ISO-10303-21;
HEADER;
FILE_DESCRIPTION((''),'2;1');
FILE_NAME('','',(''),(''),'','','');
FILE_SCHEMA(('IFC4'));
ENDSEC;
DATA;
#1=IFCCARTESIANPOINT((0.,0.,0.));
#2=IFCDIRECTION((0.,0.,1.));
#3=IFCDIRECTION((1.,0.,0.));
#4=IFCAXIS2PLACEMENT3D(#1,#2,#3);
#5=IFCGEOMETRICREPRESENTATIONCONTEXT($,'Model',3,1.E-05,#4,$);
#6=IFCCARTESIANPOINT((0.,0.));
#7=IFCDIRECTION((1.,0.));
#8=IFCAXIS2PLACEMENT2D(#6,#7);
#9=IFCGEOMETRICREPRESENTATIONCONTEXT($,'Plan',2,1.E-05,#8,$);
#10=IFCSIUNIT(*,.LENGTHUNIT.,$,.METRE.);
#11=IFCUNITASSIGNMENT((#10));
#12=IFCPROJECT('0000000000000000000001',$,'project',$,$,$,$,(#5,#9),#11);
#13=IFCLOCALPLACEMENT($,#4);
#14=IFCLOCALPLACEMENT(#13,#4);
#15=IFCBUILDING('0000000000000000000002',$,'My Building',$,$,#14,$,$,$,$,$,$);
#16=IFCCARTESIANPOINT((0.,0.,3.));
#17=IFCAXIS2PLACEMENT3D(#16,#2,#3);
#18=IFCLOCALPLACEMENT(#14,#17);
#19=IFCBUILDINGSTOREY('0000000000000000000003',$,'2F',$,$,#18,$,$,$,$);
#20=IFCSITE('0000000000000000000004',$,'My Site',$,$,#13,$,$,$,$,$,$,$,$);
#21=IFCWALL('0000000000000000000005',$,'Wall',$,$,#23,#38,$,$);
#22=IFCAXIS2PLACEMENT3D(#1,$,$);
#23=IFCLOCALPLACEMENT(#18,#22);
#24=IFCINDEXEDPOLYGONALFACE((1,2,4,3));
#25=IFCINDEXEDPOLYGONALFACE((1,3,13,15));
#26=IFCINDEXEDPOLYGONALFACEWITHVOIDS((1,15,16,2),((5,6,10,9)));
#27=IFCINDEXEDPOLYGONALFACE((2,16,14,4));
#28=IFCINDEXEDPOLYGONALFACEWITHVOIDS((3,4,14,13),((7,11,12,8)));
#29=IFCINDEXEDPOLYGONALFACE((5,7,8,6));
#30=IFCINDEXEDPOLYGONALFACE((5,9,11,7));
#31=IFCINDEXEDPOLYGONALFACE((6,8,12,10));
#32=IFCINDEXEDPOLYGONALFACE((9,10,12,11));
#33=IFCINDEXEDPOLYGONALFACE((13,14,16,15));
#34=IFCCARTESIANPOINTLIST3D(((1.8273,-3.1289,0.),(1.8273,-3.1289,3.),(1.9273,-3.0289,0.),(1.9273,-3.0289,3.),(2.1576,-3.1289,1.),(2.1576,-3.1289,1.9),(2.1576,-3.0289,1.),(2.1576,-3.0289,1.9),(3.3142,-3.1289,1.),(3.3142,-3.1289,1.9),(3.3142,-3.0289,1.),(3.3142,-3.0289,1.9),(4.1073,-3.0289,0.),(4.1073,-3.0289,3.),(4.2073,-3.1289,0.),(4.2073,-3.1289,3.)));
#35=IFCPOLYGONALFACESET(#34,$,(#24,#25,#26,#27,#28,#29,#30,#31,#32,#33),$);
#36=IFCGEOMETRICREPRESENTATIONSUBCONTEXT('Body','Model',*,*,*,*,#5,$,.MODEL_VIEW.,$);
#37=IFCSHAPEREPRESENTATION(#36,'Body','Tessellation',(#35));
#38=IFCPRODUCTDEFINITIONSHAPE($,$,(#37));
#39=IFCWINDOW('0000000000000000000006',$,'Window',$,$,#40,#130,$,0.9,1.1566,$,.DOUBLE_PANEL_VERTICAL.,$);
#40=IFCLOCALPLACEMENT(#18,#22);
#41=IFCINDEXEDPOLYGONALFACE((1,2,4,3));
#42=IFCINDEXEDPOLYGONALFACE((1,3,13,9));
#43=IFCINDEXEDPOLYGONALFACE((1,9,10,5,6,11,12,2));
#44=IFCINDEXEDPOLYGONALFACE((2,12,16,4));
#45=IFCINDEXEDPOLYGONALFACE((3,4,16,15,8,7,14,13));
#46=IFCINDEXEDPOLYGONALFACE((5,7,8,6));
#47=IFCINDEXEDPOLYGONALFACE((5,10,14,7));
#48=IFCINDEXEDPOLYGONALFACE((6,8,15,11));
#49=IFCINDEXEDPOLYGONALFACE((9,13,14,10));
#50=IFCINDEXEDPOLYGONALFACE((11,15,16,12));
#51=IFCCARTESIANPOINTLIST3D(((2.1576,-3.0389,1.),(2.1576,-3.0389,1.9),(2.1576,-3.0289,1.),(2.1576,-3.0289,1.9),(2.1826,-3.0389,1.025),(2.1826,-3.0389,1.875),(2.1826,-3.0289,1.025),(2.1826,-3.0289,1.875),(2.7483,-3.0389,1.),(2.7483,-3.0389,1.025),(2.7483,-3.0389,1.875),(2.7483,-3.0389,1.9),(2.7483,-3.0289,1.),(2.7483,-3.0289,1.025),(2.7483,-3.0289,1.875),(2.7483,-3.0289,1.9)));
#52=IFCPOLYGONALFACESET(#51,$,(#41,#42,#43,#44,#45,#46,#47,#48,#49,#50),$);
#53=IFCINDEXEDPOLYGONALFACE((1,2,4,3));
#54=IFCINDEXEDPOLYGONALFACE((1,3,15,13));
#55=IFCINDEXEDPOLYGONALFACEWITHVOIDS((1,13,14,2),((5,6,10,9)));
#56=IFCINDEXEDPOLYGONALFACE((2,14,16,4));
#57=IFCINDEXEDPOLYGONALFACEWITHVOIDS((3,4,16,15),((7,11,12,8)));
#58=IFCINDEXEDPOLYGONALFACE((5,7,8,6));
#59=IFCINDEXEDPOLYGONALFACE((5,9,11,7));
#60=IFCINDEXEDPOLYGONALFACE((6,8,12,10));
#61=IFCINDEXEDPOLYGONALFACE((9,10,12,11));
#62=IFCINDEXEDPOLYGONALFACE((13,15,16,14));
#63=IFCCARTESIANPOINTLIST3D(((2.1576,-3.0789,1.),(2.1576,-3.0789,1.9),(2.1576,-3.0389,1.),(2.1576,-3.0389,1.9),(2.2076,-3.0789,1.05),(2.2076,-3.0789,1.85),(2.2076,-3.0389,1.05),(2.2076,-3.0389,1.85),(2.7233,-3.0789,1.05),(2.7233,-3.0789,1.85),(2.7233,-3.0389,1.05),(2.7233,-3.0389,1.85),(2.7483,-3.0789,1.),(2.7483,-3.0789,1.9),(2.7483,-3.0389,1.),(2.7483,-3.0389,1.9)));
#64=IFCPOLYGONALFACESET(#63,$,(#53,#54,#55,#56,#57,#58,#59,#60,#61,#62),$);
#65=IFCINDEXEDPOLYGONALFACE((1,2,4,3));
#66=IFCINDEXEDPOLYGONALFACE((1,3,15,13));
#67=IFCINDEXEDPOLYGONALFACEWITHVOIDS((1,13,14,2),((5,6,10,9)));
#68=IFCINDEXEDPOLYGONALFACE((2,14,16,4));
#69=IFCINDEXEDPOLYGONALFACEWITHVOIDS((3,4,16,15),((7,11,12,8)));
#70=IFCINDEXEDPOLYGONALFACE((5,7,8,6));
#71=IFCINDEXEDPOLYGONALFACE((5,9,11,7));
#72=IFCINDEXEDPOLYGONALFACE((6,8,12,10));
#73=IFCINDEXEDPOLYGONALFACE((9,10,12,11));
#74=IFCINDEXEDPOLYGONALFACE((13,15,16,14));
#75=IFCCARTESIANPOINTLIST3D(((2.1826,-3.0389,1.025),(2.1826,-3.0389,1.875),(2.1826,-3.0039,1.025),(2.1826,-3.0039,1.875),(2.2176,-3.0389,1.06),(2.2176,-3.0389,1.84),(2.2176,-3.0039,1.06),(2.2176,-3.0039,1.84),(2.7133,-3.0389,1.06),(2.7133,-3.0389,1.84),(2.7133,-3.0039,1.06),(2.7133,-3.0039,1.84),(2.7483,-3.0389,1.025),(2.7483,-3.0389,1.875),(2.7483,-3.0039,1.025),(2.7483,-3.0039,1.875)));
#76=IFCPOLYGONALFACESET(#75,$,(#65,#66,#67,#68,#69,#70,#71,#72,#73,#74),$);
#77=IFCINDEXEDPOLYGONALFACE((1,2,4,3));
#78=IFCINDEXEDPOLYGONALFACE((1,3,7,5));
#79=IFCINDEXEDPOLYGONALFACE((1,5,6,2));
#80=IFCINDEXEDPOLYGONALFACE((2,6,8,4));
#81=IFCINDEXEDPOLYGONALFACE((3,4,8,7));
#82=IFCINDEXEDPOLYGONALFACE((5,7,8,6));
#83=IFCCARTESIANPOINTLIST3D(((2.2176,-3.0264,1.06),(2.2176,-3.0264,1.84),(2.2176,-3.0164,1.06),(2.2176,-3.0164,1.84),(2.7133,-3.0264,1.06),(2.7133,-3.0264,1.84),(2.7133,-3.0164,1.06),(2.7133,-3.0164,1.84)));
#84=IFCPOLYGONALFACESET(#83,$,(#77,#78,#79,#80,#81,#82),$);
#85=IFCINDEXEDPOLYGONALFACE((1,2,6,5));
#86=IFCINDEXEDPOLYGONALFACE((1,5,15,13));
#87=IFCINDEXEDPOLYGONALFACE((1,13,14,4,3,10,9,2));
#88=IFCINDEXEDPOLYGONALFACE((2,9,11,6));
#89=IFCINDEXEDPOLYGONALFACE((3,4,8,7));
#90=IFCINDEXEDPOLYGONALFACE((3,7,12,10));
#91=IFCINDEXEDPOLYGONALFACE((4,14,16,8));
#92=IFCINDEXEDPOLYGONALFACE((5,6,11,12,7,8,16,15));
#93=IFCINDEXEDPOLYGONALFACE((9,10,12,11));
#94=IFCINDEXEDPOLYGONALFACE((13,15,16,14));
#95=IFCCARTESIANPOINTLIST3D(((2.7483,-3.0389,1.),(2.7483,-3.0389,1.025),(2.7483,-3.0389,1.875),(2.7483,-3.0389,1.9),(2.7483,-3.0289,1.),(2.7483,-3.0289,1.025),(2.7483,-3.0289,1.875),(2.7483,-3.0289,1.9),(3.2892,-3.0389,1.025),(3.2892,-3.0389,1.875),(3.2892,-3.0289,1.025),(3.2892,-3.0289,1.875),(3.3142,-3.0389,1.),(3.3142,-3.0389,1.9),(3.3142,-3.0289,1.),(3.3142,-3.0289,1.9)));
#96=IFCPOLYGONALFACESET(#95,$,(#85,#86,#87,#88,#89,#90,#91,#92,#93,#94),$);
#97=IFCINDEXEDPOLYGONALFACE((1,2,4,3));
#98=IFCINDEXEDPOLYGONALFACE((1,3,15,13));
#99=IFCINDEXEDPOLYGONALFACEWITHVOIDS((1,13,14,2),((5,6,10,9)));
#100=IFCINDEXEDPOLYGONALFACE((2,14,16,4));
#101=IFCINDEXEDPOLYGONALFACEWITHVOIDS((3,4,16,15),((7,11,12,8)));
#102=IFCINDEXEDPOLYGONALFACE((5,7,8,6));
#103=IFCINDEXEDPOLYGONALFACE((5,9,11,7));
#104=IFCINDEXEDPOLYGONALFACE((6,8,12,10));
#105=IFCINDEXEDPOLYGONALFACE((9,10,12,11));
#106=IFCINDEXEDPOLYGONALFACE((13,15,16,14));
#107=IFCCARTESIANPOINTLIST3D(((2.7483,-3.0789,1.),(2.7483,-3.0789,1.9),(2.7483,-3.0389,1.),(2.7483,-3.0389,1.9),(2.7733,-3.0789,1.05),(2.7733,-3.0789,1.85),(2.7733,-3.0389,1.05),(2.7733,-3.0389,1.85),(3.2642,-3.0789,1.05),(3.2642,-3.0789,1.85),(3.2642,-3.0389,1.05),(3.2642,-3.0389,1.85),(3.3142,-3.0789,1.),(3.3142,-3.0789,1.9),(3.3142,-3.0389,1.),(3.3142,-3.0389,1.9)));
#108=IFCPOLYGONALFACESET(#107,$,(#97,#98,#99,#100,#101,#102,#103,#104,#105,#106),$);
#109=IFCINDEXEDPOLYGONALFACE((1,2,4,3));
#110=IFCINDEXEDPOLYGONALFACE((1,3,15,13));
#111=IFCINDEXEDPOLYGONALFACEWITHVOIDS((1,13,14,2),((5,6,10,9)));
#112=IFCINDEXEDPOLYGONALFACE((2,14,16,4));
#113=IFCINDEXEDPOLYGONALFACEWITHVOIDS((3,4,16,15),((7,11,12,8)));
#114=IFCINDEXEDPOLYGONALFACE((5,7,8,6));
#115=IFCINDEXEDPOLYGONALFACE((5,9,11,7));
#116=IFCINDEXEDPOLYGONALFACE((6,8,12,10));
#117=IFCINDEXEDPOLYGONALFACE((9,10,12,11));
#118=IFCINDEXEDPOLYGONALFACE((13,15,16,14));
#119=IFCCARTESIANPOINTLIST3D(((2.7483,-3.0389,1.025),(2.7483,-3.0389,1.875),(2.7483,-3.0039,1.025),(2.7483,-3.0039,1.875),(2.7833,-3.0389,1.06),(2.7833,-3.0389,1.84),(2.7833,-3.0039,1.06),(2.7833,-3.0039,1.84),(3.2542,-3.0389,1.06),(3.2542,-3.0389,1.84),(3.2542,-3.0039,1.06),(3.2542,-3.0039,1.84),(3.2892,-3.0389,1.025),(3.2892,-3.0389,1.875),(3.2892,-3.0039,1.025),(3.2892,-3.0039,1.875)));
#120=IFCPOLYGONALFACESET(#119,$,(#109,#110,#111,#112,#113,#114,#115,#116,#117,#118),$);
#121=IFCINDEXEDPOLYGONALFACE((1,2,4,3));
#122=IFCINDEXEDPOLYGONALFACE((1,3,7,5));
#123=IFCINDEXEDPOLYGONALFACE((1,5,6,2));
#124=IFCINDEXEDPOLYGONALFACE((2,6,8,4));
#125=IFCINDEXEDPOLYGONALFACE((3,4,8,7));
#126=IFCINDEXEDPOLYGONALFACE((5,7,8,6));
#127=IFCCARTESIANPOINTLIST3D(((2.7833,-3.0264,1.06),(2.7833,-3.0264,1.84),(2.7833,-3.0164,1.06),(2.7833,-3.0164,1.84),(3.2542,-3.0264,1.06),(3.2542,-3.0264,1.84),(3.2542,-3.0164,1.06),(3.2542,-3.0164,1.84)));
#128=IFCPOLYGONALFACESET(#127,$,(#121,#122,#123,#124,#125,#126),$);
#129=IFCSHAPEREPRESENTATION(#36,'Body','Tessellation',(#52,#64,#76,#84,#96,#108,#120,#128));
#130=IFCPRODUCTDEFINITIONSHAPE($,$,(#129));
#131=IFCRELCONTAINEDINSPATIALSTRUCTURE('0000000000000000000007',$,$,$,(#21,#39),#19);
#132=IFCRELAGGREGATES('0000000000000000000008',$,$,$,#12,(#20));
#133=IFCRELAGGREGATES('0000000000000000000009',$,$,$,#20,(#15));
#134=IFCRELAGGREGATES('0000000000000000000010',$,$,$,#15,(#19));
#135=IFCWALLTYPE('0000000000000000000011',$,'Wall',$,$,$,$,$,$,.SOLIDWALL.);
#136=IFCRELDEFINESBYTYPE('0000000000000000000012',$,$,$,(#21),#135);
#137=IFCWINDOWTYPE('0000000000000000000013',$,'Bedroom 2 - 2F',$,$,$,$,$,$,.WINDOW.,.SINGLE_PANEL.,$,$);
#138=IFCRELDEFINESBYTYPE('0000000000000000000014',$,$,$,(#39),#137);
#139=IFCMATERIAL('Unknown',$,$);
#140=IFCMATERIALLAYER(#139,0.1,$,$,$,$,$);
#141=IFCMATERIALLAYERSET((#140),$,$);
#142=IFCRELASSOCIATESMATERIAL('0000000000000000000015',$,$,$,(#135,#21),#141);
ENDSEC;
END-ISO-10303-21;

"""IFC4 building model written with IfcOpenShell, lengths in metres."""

from ifc_helpers import new_model, entity, si_unit, frame, origin_with_axes, origin_2d_with_axis, place, context, subcontext, project, spatial, line, indexed_curve, outline, extrude, shape, source, transform, mapped, material, layer, layer_set, layer_usage, type_object, type_shapes, element, fill, save


model = new_model("IFC4")

# Units and contexts
model_context = context("Model", 3, precision=1e-05, world=origin_with_axes())
plan_context = context("Plan", 2, precision=1e-05, world=origin_2d_with_axis())
body_context_1 = subcontext(model_context, "Body", "Model", "MODEL_VIEW")
body_context_2 = subcontext(plan_context, "Body", "Plan", "PLAN_VIEW")
ifc_project = project(units=[si_unit("LENGTHUNIT", "METRE")], contexts=[model_context, plan_context])

# Site, building, storey
site_placement = place(None, origin_with_axes())
site = spatial("IfcSite", under=ifc_project, at=site_placement, Name="My Site")
building_placement = place(site_placement, origin_with_axes())
building = spatial("IfcBuilding", under=site, at=building_placement, Name="My Building")
storey_placement = place(building_placement, frame((0.0, 0.0, 3.0), z_axis=(0.0, 0.0, 1.0), x_axis=(1.0, 0.0, 0.0)))
storey = spatial("IfcBuildingStorey", under=building, at=storey_placement, Name="2F")

# Shared definitions
ifc_material_1 = material(Name="Unknown")
ifc_layer_1 = layer(ifc_material_1, 0.1)
ifc_layer_set_1 = layer_set([ifc_layer_1])
wall_type_1 = type_object("IfcWallType", Name="Wall", PredefinedType="SOLIDWALL", material=ifc_layer_set_1)

# Wall, opening, window
ifc_layer_usage_1 = layer_usage(ifc_layer_set_1, "AXIS2", "POSITIVE", 0.0)
wall_1_placement = place(storey_placement, frame((1.8273, -3.1289, 0.0), z_axis=(0.0, 0.0, 1.0), x_axis=(1.0, 0.0, 0.0)))
wall_1 = element("IfcWall", 1, at=wall_1_placement, inside=storey, type_object=wall_type_1, material=ifc_layer_usage_1, Name="Wall", context=body_context_1, shape_type="SweptSolid", body=[
    extrude(outline(indexed_curve([(0.0, 0.0), (0.1, 0.1), (2.28, 0.1), (2.38, 0.0)], segments=[line(1, 2, 3, 4, 1)])), origin_with_axes(), (0.0, 0.0, 1.0), 3.0),
])
shared_shape_1 = source(origin_with_axes(), body_context_1, "Body", "SweptSolid", [
    extrude(outline(indexed_curve([(0.0, 0.0), (1.1566, 0.0), (1.1566, 0.9), (0.0, 0.9)], segments=[line(1, 2, 3, 4, 1)])), frame((0.0, -0.6, 0.0), z_axis=(0.0, -1.0, 0.0), x_axis=(1.0, 0.0, 0.0)), (0.0, 0.0, -1.0), 1.2),
])
opening_1_placement = place(wall_1_placement, frame((0.3303, 0.0, 1.0), z_axis=(0.0, 0.0, 1.0), x_axis=(1.0, 0.0, 0.0)))
opening_1 = element("IfcOpeningElement", 2, at=opening_1_placement, cuts=wall_1, PredefinedType="OPENING", context=body_context_1, shape_type="MappedRepresentation", body=[
    mapped(shared_shape_1, transform((0.0, 0.0, 0.0), x_axis=(1.0, 0.0, 0.0), y_axis=(0.0, 1.0, 0.0), z_axis=(0.0, 0.0, 1.0), scale=1.0)),
])
window_type_1 = type_object("IfcWindowType", Name="Bedroom 2 - 2F", PartitioningType="SINGLE_PANEL", PredefinedType="WINDOW")
shared_shape_2 = source(origin_with_axes(), body_context_1, "Body", "SweptSolid", [
    extrude(outline(indexed_curve([(0.5908, 0.0), (0.0, 0.0), (0.0, 0.9), (0.5908, 0.9), (0.5908, 0.875), (0.025, 0.875), (0.025, 0.025), (0.5908, 0.025)], segments=[line(1, 2, 3, 4, 5, 6, 7, 8, 1)])), frame((0.0, 0.09, 0.0), z_axis=(0.0, -1.0, 0.0), x_axis=(1.0, 0.0, 0.0)), (0.0, 0.0, -1.0), 0.01),
    extrude(outline(indexed_curve([(0.0, 0.0), (0.5908, 0.0), (0.5908, 0.9), (0.0, 0.9)], segments=[line(1, 2, 3, 4, 1)]), holes=[indexed_curve([(0.05, 0.05), (0.5658, 0.05), (0.5658, 0.85), (0.05, 0.85)], segments=[line(1, 2, 3, 4, 1)])]), frame((0.0, 0.05, 0.0), z_axis=(0.0, -1.0, 0.0), x_axis=(1.0, 0.0, 0.0)), (0.0, 0.0, -1.0), 0.04),
    extrude(outline(indexed_curve([(0.0, 0.0), (0.5658, 0.0), (0.5658, 0.85), (0.0, 0.85)], segments=[line(1, 2, 3, 4, 1)]), holes=[indexed_curve([(0.035, 0.035), (0.5308, 0.035), (0.5308, 0.815), (0.035, 0.815)], segments=[line(1, 2, 3, 4, 1)])]), frame((0.025, 0.09, 0.025), z_axis=(0.0, -1.0, 0.0), x_axis=(1.0, 0.0, 0.0)), (0.0, 0.0, -1.0), 0.035),
    extrude(outline(indexed_curve([(0.035, 0.035), (0.5308, 0.035), (0.5308, 0.815), (0.035, 0.815)], segments=[line(1, 2, 3, 4, 1)])), frame((0.025, 0.1025, 0.025), z_axis=(0.0, -1.0, 0.0), x_axis=(1.0, 0.0, 0.0)), (0.0, 0.0, -1.0), 0.01),
    extrude(outline(indexed_curve([(0.0, 0.9), (0.5659, 0.9), (0.5659, 0.0), (0.0, 0.0), (0.0, 0.025), (0.5409, 0.025), (0.5409, 0.875), (0.0, 0.875)], segments=[line(1, 2, 3, 4, 5, 6, 7, 8, 1)])), frame((0.5908, 0.09, 0.0), z_axis=(0.0, -1.0, 0.0), x_axis=(1.0, 0.0, 0.0)), (0.0, 0.0, -1.0), 0.01),
    extrude(outline(indexed_curve([(0.0, 0.0), (0.5659, 0.0), (0.5659, 0.9), (0.0, 0.9)], segments=[line(1, 2, 3, 4, 1)]), holes=[indexed_curve([(0.025, 0.05), (0.5159, 0.05), (0.5159, 0.85), (0.025, 0.85)], segments=[line(1, 2, 3, 4, 1)])]), frame((0.5908, 0.05, 0.0), z_axis=(0.0, -1.0, 0.0), x_axis=(1.0, 0.0, 0.0)), (0.0, 0.0, -1.0), 0.04),
    extrude(outline(indexed_curve([(0.0, 0.0), (0.5409, 0.0), (0.5409, 0.85), (0.0, 0.85)], segments=[line(1, 2, 3, 4, 1)]), holes=[indexed_curve([(0.035, 0.035), (0.5059, 0.035), (0.5059, 0.815), (0.035, 0.815)], segments=[line(1, 2, 3, 4, 1)])]), frame((0.5908, 0.09, 0.025), z_axis=(0.0, -1.0, 0.0), x_axis=(1.0, 0.0, 0.0)), (0.0, 0.0, -1.0), 0.035),
    extrude(outline(indexed_curve([(0.035, 0.035), (0.5059, 0.035), (0.5059, 0.815), (0.035, 0.815)], segments=[line(1, 2, 3, 4, 1)])), frame((0.5908, 0.1025, 0.025), z_axis=(0.0, -1.0, 0.0), x_axis=(1.0, 0.0, 0.0)), (0.0, 0.0, -1.0), 0.01),
])
shared_shape_3 = source(origin_with_axes(), body_context_2, "Body", "Curve2D", [
    entity("IfcIndexedPolyCurve", entity("IfcCartesianPointList2D", [[0.05, 0.05], [0.5658, 0.05]])),
    entity("IfcIndexedPolyCurve", entity("IfcCartesianPointList2D", [[0.0, 0.1], [0.025, 0.1], [0.025, 0.09], [0.05, 0.09], [0.05, 0.05], [0.0, 0.05]]), [entity("IfcLineIndex", [1, 2, 3, 4, 5, 6, 1])]),
    entity("IfcIndexedPolyCurve", entity("IfcCartesianPointList2D", [[0.5908, 0.1], [0.5908, 0.1], [0.5908, 0.09], [0.5658, 0.09], [0.5658, 0.05], [0.5908, 0.05]])),
    entity("IfcIndexedPolyCurve", entity("IfcCartesianPointList2D", [[0.025, 0.09], [0.06, 0.09], [0.06, 0.125], [0.025, 0.125]]), [entity("IfcLineIndex", [1, 2, 3, 4, 1])]),
    entity("IfcIndexedPolyCurve", entity("IfcCartesianPointList2D", [[0.5908, 0.09], [0.5558, 0.09], [0.5558, 0.125], [0.5908, 0.125]]), [entity("IfcLineIndex", [1, 2, 3, 4, 1])]),
    entity("IfcIndexedPolyCurve", entity("IfcCartesianPointList2D", [[0.06, 0.09], [0.5558, 0.09]])),
    entity("IfcIndexedPolyCurve", entity("IfcCartesianPointList2D", [[0.06, 0.125], [0.5558, 0.125]])),
    entity("IfcIndexedPolyCurve", entity("IfcCartesianPointList2D", [[0.06, 0.1075], [0.5558, 0.1075]])),
    entity("IfcIndexedPolyCurve", entity("IfcCartesianPointList2D", [[0.6158, 0.05], [1.1066, 0.05]])),
    entity("IfcIndexedPolyCurve", entity("IfcCartesianPointList2D", [[0.5908, 0.1], [0.5908, 0.1], [0.5908, 0.09], [0.6158, 0.09], [0.6158, 0.05], [0.5908, 0.05]])),
    entity("IfcIndexedPolyCurve", entity("IfcCartesianPointList2D", [[1.1566, 0.1], [1.1316, 0.1], [1.1316, 0.09], [1.1066, 0.09], [1.1066, 0.05], [1.1566, 0.05]]), [entity("IfcLineIndex", [1, 2, 3, 4, 5, 6, 1])]),
    entity("IfcIndexedPolyCurve", entity("IfcCartesianPointList2D", [[0.5908, 0.09], [0.6258, 0.09], [0.6258, 0.125], [0.5908, 0.125]]), [entity("IfcLineIndex", [1, 2, 3, 4, 1])]),
    entity("IfcIndexedPolyCurve", entity("IfcCartesianPointList2D", [[1.1316, 0.09], [1.0966, 0.09], [1.0966, 0.125], [1.1316, 0.125]]), [entity("IfcLineIndex", [1, 2, 3, 4, 1])]),
    entity("IfcIndexedPolyCurve", entity("IfcCartesianPointList2D", [[0.6258, 0.09], [1.0966, 0.09]])),
    entity("IfcIndexedPolyCurve", entity("IfcCartesianPointList2D", [[0.6258, 0.125], [1.0966, 0.125]])),
    entity("IfcIndexedPolyCurve", entity("IfcCartesianPointList2D", [[0.6258, 0.1075], [1.0966, 0.1075]])),
])
type_shapes(window_type_1, [shared_shape_2, shared_shape_3])
window_1_placement = place(opening_1_placement, origin_with_axes())
window_1 = element("IfcWindow", 3, at=window_1_placement, inside=storey, type_object=window_type_1, Name="Window", OverallHeight=0.9, OverallWidth=1.1566, PartitioningType="DOUBLE_PANEL_VERTICAL", shapes=[
    shape(body_context_1, "Body", "MappedRepresentation", [mapped(shared_shape_2, transform((0.0, 0.0, 0.0), x_axis=(1.0, 0.0, 0.0), y_axis=(0.0, 1.0, 0.0), z_axis=(0.0, 0.0, 1.0), scale=1.0))]),
    shape(body_context_2, "Body", "MappedRepresentation", [mapped(shared_shape_3, transform((0.0, 0.0, 0.0), x_axis=(1.0, 0.0, 0.0), y_axis=(0.0, 1.0, 0.0), z_axis=(0.0, 0.0, 1.0), scale=1.0))]),
])
fill(opening_1, window_1)

save(model, "model.ifc")
